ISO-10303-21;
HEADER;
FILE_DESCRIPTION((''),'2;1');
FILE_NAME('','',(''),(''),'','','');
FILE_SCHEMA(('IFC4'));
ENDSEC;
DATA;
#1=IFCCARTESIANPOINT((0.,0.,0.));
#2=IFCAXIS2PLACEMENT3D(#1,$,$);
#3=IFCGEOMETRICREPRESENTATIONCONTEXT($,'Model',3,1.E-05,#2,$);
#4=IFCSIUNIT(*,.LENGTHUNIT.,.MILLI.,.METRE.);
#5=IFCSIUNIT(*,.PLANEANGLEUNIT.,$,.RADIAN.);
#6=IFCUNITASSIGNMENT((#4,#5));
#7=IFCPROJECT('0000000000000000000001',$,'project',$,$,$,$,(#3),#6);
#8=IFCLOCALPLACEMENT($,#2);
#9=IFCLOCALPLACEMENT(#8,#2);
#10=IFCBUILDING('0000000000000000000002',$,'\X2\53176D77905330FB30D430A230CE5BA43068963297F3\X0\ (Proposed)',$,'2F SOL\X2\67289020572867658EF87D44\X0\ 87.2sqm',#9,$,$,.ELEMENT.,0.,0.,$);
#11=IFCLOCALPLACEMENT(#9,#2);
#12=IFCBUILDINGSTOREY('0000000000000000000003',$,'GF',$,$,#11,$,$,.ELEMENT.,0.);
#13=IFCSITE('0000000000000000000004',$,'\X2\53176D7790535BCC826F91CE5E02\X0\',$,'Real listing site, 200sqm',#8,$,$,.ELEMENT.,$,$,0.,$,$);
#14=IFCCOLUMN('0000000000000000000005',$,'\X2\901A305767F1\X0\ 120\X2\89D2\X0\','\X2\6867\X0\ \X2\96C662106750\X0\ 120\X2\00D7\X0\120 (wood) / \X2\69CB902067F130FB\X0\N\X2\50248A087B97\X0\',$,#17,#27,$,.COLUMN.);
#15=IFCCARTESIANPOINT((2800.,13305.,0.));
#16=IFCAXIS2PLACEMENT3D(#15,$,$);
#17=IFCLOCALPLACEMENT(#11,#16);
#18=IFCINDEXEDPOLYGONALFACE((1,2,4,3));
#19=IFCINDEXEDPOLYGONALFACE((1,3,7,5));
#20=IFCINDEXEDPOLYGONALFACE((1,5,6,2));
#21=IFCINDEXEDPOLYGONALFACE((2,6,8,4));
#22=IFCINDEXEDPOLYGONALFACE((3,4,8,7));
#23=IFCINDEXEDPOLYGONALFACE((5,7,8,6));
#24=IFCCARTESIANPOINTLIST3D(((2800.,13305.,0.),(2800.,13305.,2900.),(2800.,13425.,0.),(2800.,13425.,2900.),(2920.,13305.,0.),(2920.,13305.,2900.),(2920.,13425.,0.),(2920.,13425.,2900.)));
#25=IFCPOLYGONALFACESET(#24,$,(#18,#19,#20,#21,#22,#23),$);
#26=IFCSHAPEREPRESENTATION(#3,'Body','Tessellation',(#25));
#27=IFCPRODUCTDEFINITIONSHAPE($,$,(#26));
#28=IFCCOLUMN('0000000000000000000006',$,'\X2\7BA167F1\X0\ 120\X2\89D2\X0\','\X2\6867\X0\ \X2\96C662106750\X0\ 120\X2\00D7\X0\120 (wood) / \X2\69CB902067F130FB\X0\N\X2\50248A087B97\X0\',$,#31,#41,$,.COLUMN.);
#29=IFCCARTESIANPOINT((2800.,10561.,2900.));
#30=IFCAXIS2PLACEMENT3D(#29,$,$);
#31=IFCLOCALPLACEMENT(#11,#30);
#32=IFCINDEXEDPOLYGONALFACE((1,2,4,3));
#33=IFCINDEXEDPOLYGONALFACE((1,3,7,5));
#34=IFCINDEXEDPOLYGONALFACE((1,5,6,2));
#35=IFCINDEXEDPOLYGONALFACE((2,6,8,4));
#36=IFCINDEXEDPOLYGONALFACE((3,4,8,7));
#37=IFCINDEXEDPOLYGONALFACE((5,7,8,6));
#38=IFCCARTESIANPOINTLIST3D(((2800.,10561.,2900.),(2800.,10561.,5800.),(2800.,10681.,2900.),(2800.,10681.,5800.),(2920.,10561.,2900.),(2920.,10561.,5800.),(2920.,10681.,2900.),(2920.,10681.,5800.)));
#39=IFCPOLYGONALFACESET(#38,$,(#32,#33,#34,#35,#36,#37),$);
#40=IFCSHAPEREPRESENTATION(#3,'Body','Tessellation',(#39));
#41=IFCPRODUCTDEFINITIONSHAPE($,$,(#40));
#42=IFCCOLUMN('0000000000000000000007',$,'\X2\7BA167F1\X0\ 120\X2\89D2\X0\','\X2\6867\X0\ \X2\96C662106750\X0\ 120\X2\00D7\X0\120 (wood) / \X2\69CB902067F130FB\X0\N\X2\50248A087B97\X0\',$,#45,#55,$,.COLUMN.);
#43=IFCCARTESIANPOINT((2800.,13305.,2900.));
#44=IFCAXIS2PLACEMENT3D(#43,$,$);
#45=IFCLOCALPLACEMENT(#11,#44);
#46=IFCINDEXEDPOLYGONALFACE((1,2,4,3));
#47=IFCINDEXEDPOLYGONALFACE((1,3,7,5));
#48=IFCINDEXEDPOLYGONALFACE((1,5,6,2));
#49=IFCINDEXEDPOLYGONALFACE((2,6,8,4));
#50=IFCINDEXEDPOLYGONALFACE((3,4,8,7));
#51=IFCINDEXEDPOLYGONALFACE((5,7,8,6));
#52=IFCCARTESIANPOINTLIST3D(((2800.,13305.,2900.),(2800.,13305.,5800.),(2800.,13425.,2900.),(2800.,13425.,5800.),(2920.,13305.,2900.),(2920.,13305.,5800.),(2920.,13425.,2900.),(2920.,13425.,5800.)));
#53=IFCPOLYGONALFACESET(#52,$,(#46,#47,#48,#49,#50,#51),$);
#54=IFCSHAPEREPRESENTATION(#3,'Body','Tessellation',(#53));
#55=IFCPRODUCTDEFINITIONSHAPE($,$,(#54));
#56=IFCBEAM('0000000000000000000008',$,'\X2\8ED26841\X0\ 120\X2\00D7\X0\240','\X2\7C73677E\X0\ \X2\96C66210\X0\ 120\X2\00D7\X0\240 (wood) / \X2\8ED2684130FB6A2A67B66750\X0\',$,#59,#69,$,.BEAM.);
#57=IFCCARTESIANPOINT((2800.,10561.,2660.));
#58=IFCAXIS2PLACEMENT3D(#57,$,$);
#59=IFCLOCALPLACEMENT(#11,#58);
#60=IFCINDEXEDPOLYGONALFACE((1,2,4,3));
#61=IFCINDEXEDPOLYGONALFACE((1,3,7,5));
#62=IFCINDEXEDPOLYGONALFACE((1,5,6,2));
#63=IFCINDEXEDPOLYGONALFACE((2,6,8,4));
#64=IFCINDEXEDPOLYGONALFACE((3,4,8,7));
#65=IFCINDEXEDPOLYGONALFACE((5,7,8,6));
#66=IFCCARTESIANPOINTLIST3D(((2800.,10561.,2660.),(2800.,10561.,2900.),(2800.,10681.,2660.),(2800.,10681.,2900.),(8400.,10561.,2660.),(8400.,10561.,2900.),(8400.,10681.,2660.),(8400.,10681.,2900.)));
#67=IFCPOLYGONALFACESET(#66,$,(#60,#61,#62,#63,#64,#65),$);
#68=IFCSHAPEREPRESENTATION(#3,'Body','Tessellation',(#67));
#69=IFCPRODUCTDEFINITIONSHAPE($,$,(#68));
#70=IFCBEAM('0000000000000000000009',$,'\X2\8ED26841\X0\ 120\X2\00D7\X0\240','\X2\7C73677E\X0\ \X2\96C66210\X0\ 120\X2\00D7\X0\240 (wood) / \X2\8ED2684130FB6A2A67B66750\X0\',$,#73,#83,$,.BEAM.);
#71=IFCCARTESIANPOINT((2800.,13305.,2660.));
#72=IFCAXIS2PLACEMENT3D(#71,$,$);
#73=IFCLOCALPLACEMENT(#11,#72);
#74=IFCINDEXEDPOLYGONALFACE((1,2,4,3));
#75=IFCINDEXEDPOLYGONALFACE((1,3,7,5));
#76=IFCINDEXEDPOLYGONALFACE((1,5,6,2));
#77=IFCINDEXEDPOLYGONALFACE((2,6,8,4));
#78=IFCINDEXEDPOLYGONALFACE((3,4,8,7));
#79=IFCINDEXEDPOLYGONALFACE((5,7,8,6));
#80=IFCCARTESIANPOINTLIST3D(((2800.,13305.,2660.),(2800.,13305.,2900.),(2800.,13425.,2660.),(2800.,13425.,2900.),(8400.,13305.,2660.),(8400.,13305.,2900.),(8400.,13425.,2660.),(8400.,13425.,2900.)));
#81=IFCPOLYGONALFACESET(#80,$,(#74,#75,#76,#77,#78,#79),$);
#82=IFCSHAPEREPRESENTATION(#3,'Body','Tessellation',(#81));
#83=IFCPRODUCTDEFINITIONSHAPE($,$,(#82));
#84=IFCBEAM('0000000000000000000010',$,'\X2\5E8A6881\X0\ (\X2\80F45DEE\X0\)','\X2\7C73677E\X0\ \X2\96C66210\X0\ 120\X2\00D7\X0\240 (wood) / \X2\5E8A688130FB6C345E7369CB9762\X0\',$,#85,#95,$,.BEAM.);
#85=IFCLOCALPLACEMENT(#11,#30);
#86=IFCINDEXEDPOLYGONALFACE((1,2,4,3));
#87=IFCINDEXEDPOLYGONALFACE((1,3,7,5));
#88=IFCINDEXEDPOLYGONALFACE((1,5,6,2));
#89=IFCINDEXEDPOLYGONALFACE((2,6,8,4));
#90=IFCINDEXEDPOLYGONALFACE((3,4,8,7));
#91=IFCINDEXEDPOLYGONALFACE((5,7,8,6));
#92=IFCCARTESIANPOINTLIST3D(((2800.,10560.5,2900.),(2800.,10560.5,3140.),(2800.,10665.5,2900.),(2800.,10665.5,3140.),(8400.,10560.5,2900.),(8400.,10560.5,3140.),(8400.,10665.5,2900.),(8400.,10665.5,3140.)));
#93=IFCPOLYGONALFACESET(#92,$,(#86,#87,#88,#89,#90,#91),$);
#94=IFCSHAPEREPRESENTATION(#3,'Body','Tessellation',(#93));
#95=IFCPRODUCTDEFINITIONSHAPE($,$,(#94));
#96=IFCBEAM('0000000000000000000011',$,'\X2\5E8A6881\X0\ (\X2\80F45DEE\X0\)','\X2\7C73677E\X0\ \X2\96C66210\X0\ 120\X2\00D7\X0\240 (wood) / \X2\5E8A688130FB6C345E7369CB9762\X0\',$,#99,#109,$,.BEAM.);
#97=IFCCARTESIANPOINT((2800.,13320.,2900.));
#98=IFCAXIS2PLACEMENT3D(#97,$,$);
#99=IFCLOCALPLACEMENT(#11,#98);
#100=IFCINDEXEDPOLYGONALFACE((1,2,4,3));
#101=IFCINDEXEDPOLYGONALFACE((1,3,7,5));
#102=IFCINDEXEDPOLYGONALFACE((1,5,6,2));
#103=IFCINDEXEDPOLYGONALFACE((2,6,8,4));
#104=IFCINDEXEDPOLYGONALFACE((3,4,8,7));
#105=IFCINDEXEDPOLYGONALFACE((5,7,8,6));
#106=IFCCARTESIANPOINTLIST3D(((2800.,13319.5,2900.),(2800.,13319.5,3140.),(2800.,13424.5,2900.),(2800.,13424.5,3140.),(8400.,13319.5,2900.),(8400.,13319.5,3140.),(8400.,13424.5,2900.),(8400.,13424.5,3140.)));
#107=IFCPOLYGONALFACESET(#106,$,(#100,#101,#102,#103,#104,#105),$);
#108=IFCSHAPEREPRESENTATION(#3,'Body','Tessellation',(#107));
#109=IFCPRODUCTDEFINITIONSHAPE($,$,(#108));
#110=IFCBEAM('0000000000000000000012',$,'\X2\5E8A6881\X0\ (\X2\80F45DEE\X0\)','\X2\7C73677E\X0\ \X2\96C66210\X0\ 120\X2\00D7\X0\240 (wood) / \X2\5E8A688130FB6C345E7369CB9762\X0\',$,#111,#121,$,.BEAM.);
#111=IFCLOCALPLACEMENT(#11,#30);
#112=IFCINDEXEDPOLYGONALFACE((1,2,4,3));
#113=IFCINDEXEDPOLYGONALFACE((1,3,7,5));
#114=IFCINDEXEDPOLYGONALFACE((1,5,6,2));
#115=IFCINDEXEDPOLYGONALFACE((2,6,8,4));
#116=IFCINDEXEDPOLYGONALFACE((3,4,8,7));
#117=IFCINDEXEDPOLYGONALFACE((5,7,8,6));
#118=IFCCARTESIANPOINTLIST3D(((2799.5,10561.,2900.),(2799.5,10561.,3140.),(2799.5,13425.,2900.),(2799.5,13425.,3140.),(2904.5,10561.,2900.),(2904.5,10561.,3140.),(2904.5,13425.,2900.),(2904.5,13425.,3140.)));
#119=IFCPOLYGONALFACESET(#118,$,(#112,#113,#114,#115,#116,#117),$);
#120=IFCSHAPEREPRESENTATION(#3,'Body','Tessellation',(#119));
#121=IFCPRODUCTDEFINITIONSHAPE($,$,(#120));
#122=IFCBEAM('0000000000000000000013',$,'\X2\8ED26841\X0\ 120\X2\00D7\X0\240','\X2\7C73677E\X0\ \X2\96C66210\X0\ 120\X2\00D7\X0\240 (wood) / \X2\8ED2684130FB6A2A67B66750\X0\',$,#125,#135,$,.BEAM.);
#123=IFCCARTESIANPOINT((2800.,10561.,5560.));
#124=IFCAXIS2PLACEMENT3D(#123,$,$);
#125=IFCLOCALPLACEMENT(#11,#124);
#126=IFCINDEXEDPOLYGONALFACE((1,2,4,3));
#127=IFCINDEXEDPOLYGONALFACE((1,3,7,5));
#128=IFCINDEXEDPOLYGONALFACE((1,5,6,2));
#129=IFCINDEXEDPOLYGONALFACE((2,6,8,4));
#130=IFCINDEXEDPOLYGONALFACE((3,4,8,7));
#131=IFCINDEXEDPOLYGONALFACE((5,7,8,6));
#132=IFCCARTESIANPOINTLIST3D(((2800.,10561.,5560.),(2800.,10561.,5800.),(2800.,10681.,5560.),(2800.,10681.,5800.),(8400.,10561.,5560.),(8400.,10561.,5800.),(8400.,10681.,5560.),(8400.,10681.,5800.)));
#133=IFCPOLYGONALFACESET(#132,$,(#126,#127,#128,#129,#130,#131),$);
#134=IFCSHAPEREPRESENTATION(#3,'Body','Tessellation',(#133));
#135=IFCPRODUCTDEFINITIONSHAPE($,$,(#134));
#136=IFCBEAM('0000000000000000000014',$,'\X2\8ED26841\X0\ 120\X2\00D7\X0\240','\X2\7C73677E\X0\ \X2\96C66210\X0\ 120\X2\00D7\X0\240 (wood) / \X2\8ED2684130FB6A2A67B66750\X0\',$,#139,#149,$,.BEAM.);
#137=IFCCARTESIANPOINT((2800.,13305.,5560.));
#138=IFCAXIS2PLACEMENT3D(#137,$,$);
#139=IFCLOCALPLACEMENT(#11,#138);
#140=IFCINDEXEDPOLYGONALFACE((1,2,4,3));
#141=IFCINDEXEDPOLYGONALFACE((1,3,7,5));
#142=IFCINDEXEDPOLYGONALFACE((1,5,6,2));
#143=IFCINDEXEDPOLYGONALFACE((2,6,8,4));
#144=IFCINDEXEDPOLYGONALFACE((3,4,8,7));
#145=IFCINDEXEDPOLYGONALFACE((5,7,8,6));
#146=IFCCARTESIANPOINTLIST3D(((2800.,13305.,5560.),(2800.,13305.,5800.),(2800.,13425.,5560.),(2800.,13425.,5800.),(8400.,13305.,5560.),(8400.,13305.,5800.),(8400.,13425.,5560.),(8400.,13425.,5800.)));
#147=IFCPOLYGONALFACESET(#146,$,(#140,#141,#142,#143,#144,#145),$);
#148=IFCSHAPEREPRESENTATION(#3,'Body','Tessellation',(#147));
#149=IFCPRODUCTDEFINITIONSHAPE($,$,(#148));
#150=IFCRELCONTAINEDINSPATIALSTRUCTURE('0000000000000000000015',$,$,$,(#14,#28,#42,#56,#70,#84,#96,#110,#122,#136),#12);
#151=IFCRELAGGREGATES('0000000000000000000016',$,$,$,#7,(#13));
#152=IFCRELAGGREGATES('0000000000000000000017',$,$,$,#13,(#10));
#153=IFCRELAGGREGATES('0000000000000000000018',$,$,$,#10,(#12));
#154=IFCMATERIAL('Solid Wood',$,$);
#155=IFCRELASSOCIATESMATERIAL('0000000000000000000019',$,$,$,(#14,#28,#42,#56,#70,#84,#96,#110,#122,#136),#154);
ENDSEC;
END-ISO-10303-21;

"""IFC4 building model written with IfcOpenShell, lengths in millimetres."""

from ifc_helpers import new_model, si_unit, frame, frame_2d, origin, place, context, project, spatial, rectangle, extrude, material, element, save


model = new_model("IFC4")

# Units and contexts
model_context = context("Model", 3, precision=1e-05, world=origin())
ifc_project = project(units=[si_unit("LENGTHUNIT", "METRE", prefix="MILLI"), si_unit("PLANEANGLEUNIT", "RADIAN")], contexts=[model_context])

# Site, building, storey
site_placement = place(None, origin())
site = spatial("IfcSite", under=ifc_project, at=site_placement, Name="北海道富良野市", ObjectType="Real listing site, 200sqm", CompositionType="ELEMENT", RefElevation=0.0)
building_placement = place(site_placement, origin())
building = spatial("IfcBuilding", under=site, at=building_placement, Name="北海道・ピアノ室と防音 (Proposed)", ObjectType="2F SOL木造在来軸組 87.2sqm", CompositionType="ELEMENT", ElevationOfRefHeight=0.0, ElevationOfTerrain=0.0)
storey_placement = place(building_placement, origin())
storey = spatial("IfcBuildingStorey", under=building, at=storey_placement, Name="GF", CompositionType="ELEMENT", Elevation=0.0)

# Columns
ifc_material_1 = material(Name="Solid Wood")
column_1_placement = place(storey_placement, frame((2800.0, 13305.0, 0.0)))
element("IfcColumn", 1, at=column_1_placement, inside=storey, material=ifc_material_1, Name="通し柱 120角", Description="桧 集成材 120×120 (wood) / 構造柱・N値計算", PredefinedType="COLUMN", context=model_context, shape_type="SweptSolid", body=[
    extrude(rectangle(XDim=120.0, YDim=120.0, at=frame_2d((60.0, 60.0))), frame((2800.0, 13305.0, 0.0)), (0.0, 0.0, 1.0), 2900.0),
])
column_2_placement = place(storey_placement, frame((2800.0, 10561.0, 2900.0)))
element("IfcColumn", 2, at=column_2_placement, inside=storey, material=ifc_material_1, Name="管柱 120角", Description="桧 集成材 120×120 (wood) / 構造柱・N値計算", PredefinedType="COLUMN", context=model_context, shape_type="SweptSolid", body=[
    extrude(rectangle(XDim=120.0, YDim=120.0, at=frame_2d((60.0, 60.0))), frame((2800.0, 10561.0, 2900.0)), (0.0, 0.0, 1.0), 2900.0),
])
column_3_placement = place(storey_placement, frame((2800.0, 13305.0, 2900.0)))
element("IfcColumn", 3, at=column_3_placement, inside=storey, material=ifc_material_1, Name="管柱 120角", Description="桧 集成材 120×120 (wood) / 構造柱・N値計算", PredefinedType="COLUMN", context=model_context, shape_type="SweptSolid", body=[
    extrude(rectangle(XDim=120.0, YDim=120.0, at=frame_2d((60.0, 60.0))), frame((2800.0, 13305.0, 2900.0)), (0.0, 0.0, 1.0), 2900.0),
])

# Beams
beam_1_placement = place(storey_placement, frame((2800.0, 10561.0, 2660.0)))
element("IfcBeam", 4, at=beam_1_placement, inside=storey, material=ifc_material_1, Name="軒桁 120×240", Description="米松 集成 120×240 (wood) / 軒桁・横架材", PredefinedType="BEAM", context=model_context, shape_type="SweptSolid", body=[
    extrude(rectangle(XDim=5600.0, YDim=120.0, at=frame_2d((2800.0, 60.0))), frame((2800.0, 10561.0, 2660.0)), (0.0, 0.0, 1.0), 240.0),
])
beam_2_placement = place(storey_placement, frame((2800.0, 13305.0, 2660.0)))
element("IfcBeam", 5, at=beam_2_placement, inside=storey, material=ifc_material_1, Name="軒桁 120×240", Description="米松 集成 120×240 (wood) / 軒桁・横架材", PredefinedType="BEAM", context=model_context, shape_type="SweptSolid", body=[
    extrude(rectangle(XDim=5600.0, YDim=120.0, at=frame_2d((2800.0, 60.0))), frame((2800.0, 13305.0, 2660.0)), (0.0, 0.0, 1.0), 240.0),
])
beam_3_placement = place(storey_placement, frame((2800.0, 10561.0, 2900.0)))
element("IfcBeam", 6, at=beam_3_placement, inside=storey, material=ifc_material_1, Name="床梁 (胴差)", Description="米松 集成 120×240 (wood) / 床梁・水平構面", PredefinedType="BEAM", context=model_context, shape_type="SweptSolid", body=[
    extrude(rectangle(XDim=5600.0, YDim=105.0, at=frame_2d((2800.0, 52.0))), frame((2800.0, 10561.0, 2900.0)), (0.0, 0.0, 1.0), 240.0),
])
beam_4_placement = place(storey_placement, frame((2800.0, 13320.0, 2900.0)))
element("IfcBeam", 7, at=beam_4_placement, inside=storey, material=ifc_material_1, Name="床梁 (胴差)", Description="米松 集成 120×240 (wood) / 床梁・水平構面", PredefinedType="BEAM", context=model_context, shape_type="SweptSolid", body=[
    extrude(rectangle(XDim=5600.0, YDim=105.0, at=frame_2d((2800.0, 52.0))), frame((2800.0, 13320.0, 2900.0)), (0.0, 0.0, 1.0), 240.0),
])
beam_5_placement = place(storey_placement, frame((2800.0, 10561.0, 2900.0)))
element("IfcBeam", 8, at=beam_5_placement, inside=storey, material=ifc_material_1, Name="床梁 (胴差)", Description="米松 集成 120×240 (wood) / 床梁・水平構面", PredefinedType="BEAM", context=model_context, shape_type="SweptSolid", body=[
    extrude(rectangle(XDim=105.0, YDim=2864.0, at=frame_2d((52.0, 1432.0))), frame((2800.0, 10561.0, 2900.0)), (0.0, 0.0, 1.0), 240.0),
])
beam_6_placement = place(storey_placement, frame((2800.0, 10561.0, 5560.0)))
element("IfcBeam", 9, at=beam_6_placement, inside=storey, material=ifc_material_1, Name="軒桁 120×240", Description="米松 集成 120×240 (wood) / 軒桁・横架材", PredefinedType="BEAM", context=model_context, shape_type="SweptSolid", body=[
    extrude(rectangle(XDim=5600.0, YDim=120.0, at=frame_2d((2800.0, 60.0))), frame((2800.0, 10561.0, 5560.0)), (0.0, 0.0, 1.0), 240.0),
])
beam_7_placement = place(storey_placement, frame((2800.0, 13305.0, 5560.0)))
element("IfcBeam", 10, at=beam_7_placement, inside=storey, material=ifc_material_1, Name="軒桁 120×240", Description="米松 集成 120×240 (wood) / 軒桁・横架材", PredefinedType="BEAM", context=model_context, shape_type="SweptSolid", body=[
    extrude(rectangle(XDim=5600.0, YDim=120.0, at=frame_2d((2800.0, 60.0))), frame((2800.0, 13305.0, 5560.0)), (0.0, 0.0, 1.0), 240.0),
])

save(model, "model.ifc")
